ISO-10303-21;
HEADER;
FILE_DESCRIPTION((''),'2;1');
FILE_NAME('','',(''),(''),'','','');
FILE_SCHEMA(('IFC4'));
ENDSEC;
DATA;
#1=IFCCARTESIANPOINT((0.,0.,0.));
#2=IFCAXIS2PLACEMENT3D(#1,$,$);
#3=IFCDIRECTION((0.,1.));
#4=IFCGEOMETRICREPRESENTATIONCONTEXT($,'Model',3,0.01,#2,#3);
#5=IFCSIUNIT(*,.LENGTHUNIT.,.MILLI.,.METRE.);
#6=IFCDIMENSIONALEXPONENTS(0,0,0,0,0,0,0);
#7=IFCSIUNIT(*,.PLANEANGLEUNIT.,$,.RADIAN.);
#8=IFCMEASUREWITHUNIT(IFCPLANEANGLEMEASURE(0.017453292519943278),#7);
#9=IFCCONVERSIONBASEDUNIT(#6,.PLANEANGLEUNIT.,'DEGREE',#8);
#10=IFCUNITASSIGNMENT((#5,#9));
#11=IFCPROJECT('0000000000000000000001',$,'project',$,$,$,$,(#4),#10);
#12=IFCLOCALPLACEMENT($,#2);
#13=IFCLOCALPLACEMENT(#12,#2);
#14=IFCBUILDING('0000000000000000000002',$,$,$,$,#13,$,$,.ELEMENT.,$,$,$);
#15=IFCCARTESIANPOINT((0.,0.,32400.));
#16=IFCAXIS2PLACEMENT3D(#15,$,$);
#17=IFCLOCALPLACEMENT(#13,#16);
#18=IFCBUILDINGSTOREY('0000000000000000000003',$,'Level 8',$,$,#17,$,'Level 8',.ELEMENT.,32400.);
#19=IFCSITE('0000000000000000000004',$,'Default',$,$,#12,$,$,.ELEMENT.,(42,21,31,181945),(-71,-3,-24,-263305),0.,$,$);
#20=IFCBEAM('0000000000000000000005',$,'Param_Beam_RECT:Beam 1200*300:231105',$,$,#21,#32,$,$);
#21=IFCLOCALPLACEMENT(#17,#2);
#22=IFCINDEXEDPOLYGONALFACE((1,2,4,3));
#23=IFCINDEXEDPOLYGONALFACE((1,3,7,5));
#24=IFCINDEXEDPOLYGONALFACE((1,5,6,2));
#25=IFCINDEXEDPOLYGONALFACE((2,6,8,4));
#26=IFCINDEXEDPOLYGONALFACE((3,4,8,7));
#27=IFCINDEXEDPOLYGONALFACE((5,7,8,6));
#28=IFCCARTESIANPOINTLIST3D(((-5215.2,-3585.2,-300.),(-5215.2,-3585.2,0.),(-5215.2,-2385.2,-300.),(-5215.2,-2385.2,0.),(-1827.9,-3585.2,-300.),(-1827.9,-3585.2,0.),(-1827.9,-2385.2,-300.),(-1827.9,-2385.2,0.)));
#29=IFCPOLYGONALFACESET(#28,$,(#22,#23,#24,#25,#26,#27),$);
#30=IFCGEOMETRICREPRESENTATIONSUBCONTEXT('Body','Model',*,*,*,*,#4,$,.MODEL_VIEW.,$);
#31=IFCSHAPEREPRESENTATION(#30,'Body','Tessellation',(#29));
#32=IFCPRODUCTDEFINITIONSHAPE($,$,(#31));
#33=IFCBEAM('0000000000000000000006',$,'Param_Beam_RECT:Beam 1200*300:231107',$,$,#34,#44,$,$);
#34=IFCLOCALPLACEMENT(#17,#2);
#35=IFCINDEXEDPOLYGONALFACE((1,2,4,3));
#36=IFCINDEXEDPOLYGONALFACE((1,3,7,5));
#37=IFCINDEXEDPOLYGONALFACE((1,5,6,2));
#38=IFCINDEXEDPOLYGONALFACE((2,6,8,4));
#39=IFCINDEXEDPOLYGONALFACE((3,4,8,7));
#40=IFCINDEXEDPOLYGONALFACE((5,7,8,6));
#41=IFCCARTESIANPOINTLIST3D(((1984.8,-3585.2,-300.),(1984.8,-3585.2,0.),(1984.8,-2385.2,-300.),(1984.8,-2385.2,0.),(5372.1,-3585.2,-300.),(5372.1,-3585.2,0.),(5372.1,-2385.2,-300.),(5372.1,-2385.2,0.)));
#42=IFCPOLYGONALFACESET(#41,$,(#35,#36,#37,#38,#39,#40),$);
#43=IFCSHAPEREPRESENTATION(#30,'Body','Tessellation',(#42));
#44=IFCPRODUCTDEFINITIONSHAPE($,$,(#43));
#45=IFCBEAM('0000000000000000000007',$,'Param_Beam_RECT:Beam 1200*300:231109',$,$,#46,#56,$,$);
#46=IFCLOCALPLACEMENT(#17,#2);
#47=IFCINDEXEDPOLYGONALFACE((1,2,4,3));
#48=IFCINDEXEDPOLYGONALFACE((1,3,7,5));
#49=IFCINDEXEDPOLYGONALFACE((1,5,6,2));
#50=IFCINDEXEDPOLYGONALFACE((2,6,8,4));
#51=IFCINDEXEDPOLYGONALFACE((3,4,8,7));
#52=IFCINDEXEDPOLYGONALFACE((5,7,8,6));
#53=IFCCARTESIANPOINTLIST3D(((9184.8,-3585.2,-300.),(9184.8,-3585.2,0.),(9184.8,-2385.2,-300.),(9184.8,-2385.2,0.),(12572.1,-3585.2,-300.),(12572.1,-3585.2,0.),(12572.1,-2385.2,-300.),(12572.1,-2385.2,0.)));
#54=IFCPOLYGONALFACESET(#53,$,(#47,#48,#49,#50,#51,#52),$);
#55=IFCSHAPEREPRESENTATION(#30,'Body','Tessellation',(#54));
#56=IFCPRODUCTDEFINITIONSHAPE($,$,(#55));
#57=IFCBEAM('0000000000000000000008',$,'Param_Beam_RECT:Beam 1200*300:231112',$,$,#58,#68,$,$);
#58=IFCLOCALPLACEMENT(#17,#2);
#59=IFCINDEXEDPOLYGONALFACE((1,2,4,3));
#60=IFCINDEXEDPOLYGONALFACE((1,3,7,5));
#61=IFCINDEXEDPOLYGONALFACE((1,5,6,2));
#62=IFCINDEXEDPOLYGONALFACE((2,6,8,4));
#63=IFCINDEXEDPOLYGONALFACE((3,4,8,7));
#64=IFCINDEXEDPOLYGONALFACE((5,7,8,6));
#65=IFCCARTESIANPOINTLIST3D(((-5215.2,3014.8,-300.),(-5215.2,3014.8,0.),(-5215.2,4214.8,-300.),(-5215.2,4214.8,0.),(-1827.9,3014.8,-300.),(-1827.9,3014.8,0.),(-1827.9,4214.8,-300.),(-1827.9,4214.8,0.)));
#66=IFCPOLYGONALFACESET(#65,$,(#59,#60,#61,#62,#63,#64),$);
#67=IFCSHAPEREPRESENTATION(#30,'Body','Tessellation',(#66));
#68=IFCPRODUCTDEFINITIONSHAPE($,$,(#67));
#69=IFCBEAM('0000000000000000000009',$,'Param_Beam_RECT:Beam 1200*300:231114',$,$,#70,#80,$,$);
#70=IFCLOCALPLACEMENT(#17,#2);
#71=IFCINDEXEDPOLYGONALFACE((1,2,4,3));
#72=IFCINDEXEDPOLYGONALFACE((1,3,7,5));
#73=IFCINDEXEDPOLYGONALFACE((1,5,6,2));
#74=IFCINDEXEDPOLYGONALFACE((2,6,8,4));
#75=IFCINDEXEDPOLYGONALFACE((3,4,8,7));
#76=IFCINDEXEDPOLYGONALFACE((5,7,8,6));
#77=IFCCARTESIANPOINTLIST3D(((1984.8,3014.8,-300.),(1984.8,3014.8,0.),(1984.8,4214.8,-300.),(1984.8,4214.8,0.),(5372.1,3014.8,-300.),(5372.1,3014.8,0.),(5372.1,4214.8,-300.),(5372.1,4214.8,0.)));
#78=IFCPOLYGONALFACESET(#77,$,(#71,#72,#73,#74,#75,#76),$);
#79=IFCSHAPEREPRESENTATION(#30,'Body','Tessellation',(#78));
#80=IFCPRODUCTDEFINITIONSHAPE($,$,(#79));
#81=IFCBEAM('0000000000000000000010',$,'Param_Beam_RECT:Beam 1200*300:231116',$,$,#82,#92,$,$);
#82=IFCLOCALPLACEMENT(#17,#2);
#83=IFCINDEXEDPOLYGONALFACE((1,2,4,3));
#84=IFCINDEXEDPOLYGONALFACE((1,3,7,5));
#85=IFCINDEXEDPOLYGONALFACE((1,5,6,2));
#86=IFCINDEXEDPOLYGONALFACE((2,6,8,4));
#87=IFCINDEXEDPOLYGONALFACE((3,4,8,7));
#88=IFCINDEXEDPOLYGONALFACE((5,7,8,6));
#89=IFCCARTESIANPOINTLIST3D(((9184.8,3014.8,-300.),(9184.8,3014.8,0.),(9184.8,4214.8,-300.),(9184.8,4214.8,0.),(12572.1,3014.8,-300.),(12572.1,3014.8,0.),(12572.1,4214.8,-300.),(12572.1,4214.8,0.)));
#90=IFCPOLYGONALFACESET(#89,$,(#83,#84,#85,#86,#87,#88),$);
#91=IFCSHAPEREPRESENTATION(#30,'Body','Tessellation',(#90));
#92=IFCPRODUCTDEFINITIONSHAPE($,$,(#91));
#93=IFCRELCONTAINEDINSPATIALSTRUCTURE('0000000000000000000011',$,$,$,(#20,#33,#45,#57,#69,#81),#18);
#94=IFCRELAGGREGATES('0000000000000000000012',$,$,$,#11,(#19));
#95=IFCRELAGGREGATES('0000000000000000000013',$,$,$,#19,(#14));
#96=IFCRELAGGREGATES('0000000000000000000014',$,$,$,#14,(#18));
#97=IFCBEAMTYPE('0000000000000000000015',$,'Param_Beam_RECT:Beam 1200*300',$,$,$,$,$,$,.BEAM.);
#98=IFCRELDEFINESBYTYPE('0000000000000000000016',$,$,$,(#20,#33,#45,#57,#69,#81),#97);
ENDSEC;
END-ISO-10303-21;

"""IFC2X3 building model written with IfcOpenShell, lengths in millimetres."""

from ifc_helpers import new_model, entity, si_unit, converted_unit, direction, frame, frame_2d, origin, place, context, subcontext, project, spatial, rectangle, extrude, type_object, element, save


model = new_model("IFC2X3")

# Units and contexts
model_context = context("Model", 3, precision=0.01, world=origin(), true_north=direction((0.0, 1.0)))
body_context = subcontext(model_context, "Body", "Model", "MODEL_VIEW")
ifc_project = project(units=[si_unit("LENGTHUNIT", "METRE", prefix="MILLI"), converted_unit("PLANEANGLEUNIT", "DEGREE", entity("IfcPlaneAngleMeasure", 0.017453292519943278), si_unit("PLANEANGLEUNIT", "RADIAN"), dimensions=[0, 0, 0, 0, 0, 0, 0])], contexts=[model_context])

# Site, building, storey
site_placement = place(None, origin())
site = spatial("IfcSite", under=ifc_project, at=site_placement, Name="Default", CompositionType="ELEMENT", RefLatitude=(42, 21, 31, 181945), RefLongitude=(-71, -3, -24, -263305), RefElevation=0.0)
building_placement = place(site_placement, origin())
building = spatial("IfcBuilding", under=site, at=building_placement, CompositionType="ELEMENT")
storey_placement = place(building_placement, frame((0.0, 0.0, 32400.0)))
storey = spatial("IfcBuildingStorey", under=building, at=storey_placement, Name="Level 8", LongName="Level 8", CompositionType="ELEMENT", Elevation=32400.0)

# Beams
beam_type_1 = type_object("IfcBeamType", Name="Param_Beam_RECT:Beam 1200*300", PredefinedType="BEAM")
beam_1_placement = place(storey_placement, frame((-5215.2, -2985.2, 0.0)))
element("IfcBeam", 1, at=beam_1_placement, inside=storey, type_object=beam_type_1, Name="Param_Beam_RECT:Beam 1200*300:231105", context=body_context, shape_type="SweptSolid", body=[
    extrude(rectangle(XDim=300.0, YDim=1200.0, at=frame_2d((0.0, 0.0), x_axis=(1.0, 0.0))), frame((0.0, 0.0, -150.0), z_axis=(1.0, 0.0, 0.0), x_axis=(0.0, 0.0, -1.0)), (0.0, 0.0, 1.0), 3387.3),
])
beam_2_placement = place(storey_placement, frame((1984.8, -2985.2, 0.0)))
element("IfcBeam", 2, at=beam_2_placement, inside=storey, type_object=beam_type_1, Name="Param_Beam_RECT:Beam 1200*300:231107", context=body_context, shape_type="SweptSolid", body=[
    extrude(rectangle(XDim=300.0, YDim=1200.0, at=frame_2d((0.0, 0.0), x_axis=(1.0, 0.0))), frame((0.0, 0.0, -150.0), z_axis=(1.0, 0.0, 0.0), x_axis=(0.0, 0.0, -1.0)), (0.0, 0.0, 1.0), 3387.3),
])
beam_3_placement = place(storey_placement, frame((9184.8, -2985.2, 0.0)))
element("IfcBeam", 3, at=beam_3_placement, inside=storey, type_object=beam_type_1, Name="Param_Beam_RECT:Beam 1200*300:231109", context=body_context, shape_type="SweptSolid", body=[
    extrude(rectangle(XDim=300.0, YDim=1200.0, at=frame_2d((0.0, 0.0), x_axis=(1.0, 0.0))), frame((0.0, 0.0, -150.0), z_axis=(1.0, 0.0, 0.0), x_axis=(0.0, 0.0, -1.0)), (0.0, 0.0, 1.0), 3387.3),
])
beam_4_placement = place(storey_placement, frame((-5215.2, 3614.8, 0.0)))
element("IfcBeam", 4, at=beam_4_placement, inside=storey, type_object=beam_type_1, Name="Param_Beam_RECT:Beam 1200*300:231112", context=body_context, shape_type="SweptSolid", body=[
    extrude(rectangle(XDim=300.0, YDim=1200.0, at=frame_2d((0.0, 0.0), x_axis=(1.0, 0.0))), frame((0.0, 0.0, -150.0), z_axis=(1.0, 0.0, 0.0), x_axis=(0.0, 0.0, -1.0)), (0.0, 0.0, 1.0), 3387.3),
])
beam_5_placement = place(storey_placement, frame((1984.8, 3614.8, 0.0)))
element("IfcBeam", 5, at=beam_5_placement, inside=storey, type_object=beam_type_1, Name="Param_Beam_RECT:Beam 1200*300:231114", context=body_context, shape_type="SweptSolid", body=[
    extrude(rectangle(XDim=300.0, YDim=1200.0, at=frame_2d((0.0, 0.0), x_axis=(1.0, 0.0))), frame((0.0, 0.0, -150.0), z_axis=(1.0, 0.0, 0.0), x_axis=(0.0, 0.0, -1.0)), (0.0, 0.0, 1.0), 3387.3),
])
beam_6_placement = place(storey_placement, frame((9184.8, 3614.8, 0.0)))
element("IfcBeam", 6, at=beam_6_placement, inside=storey, type_object=beam_type_1, Name="Param_Beam_RECT:Beam 1200*300:231116", context=body_context, shape_type="SweptSolid", body=[
    extrude(rectangle(XDim=300.0, YDim=1200.0, at=frame_2d((0.0, 0.0), x_axis=(1.0, 0.0))), frame((0.0, 0.0, -150.0), z_axis=(1.0, 0.0, 0.0), x_axis=(0.0, 0.0, -1.0)), (0.0, 0.0, 1.0), 3387.3),
])

save(model, "model.ifc")
